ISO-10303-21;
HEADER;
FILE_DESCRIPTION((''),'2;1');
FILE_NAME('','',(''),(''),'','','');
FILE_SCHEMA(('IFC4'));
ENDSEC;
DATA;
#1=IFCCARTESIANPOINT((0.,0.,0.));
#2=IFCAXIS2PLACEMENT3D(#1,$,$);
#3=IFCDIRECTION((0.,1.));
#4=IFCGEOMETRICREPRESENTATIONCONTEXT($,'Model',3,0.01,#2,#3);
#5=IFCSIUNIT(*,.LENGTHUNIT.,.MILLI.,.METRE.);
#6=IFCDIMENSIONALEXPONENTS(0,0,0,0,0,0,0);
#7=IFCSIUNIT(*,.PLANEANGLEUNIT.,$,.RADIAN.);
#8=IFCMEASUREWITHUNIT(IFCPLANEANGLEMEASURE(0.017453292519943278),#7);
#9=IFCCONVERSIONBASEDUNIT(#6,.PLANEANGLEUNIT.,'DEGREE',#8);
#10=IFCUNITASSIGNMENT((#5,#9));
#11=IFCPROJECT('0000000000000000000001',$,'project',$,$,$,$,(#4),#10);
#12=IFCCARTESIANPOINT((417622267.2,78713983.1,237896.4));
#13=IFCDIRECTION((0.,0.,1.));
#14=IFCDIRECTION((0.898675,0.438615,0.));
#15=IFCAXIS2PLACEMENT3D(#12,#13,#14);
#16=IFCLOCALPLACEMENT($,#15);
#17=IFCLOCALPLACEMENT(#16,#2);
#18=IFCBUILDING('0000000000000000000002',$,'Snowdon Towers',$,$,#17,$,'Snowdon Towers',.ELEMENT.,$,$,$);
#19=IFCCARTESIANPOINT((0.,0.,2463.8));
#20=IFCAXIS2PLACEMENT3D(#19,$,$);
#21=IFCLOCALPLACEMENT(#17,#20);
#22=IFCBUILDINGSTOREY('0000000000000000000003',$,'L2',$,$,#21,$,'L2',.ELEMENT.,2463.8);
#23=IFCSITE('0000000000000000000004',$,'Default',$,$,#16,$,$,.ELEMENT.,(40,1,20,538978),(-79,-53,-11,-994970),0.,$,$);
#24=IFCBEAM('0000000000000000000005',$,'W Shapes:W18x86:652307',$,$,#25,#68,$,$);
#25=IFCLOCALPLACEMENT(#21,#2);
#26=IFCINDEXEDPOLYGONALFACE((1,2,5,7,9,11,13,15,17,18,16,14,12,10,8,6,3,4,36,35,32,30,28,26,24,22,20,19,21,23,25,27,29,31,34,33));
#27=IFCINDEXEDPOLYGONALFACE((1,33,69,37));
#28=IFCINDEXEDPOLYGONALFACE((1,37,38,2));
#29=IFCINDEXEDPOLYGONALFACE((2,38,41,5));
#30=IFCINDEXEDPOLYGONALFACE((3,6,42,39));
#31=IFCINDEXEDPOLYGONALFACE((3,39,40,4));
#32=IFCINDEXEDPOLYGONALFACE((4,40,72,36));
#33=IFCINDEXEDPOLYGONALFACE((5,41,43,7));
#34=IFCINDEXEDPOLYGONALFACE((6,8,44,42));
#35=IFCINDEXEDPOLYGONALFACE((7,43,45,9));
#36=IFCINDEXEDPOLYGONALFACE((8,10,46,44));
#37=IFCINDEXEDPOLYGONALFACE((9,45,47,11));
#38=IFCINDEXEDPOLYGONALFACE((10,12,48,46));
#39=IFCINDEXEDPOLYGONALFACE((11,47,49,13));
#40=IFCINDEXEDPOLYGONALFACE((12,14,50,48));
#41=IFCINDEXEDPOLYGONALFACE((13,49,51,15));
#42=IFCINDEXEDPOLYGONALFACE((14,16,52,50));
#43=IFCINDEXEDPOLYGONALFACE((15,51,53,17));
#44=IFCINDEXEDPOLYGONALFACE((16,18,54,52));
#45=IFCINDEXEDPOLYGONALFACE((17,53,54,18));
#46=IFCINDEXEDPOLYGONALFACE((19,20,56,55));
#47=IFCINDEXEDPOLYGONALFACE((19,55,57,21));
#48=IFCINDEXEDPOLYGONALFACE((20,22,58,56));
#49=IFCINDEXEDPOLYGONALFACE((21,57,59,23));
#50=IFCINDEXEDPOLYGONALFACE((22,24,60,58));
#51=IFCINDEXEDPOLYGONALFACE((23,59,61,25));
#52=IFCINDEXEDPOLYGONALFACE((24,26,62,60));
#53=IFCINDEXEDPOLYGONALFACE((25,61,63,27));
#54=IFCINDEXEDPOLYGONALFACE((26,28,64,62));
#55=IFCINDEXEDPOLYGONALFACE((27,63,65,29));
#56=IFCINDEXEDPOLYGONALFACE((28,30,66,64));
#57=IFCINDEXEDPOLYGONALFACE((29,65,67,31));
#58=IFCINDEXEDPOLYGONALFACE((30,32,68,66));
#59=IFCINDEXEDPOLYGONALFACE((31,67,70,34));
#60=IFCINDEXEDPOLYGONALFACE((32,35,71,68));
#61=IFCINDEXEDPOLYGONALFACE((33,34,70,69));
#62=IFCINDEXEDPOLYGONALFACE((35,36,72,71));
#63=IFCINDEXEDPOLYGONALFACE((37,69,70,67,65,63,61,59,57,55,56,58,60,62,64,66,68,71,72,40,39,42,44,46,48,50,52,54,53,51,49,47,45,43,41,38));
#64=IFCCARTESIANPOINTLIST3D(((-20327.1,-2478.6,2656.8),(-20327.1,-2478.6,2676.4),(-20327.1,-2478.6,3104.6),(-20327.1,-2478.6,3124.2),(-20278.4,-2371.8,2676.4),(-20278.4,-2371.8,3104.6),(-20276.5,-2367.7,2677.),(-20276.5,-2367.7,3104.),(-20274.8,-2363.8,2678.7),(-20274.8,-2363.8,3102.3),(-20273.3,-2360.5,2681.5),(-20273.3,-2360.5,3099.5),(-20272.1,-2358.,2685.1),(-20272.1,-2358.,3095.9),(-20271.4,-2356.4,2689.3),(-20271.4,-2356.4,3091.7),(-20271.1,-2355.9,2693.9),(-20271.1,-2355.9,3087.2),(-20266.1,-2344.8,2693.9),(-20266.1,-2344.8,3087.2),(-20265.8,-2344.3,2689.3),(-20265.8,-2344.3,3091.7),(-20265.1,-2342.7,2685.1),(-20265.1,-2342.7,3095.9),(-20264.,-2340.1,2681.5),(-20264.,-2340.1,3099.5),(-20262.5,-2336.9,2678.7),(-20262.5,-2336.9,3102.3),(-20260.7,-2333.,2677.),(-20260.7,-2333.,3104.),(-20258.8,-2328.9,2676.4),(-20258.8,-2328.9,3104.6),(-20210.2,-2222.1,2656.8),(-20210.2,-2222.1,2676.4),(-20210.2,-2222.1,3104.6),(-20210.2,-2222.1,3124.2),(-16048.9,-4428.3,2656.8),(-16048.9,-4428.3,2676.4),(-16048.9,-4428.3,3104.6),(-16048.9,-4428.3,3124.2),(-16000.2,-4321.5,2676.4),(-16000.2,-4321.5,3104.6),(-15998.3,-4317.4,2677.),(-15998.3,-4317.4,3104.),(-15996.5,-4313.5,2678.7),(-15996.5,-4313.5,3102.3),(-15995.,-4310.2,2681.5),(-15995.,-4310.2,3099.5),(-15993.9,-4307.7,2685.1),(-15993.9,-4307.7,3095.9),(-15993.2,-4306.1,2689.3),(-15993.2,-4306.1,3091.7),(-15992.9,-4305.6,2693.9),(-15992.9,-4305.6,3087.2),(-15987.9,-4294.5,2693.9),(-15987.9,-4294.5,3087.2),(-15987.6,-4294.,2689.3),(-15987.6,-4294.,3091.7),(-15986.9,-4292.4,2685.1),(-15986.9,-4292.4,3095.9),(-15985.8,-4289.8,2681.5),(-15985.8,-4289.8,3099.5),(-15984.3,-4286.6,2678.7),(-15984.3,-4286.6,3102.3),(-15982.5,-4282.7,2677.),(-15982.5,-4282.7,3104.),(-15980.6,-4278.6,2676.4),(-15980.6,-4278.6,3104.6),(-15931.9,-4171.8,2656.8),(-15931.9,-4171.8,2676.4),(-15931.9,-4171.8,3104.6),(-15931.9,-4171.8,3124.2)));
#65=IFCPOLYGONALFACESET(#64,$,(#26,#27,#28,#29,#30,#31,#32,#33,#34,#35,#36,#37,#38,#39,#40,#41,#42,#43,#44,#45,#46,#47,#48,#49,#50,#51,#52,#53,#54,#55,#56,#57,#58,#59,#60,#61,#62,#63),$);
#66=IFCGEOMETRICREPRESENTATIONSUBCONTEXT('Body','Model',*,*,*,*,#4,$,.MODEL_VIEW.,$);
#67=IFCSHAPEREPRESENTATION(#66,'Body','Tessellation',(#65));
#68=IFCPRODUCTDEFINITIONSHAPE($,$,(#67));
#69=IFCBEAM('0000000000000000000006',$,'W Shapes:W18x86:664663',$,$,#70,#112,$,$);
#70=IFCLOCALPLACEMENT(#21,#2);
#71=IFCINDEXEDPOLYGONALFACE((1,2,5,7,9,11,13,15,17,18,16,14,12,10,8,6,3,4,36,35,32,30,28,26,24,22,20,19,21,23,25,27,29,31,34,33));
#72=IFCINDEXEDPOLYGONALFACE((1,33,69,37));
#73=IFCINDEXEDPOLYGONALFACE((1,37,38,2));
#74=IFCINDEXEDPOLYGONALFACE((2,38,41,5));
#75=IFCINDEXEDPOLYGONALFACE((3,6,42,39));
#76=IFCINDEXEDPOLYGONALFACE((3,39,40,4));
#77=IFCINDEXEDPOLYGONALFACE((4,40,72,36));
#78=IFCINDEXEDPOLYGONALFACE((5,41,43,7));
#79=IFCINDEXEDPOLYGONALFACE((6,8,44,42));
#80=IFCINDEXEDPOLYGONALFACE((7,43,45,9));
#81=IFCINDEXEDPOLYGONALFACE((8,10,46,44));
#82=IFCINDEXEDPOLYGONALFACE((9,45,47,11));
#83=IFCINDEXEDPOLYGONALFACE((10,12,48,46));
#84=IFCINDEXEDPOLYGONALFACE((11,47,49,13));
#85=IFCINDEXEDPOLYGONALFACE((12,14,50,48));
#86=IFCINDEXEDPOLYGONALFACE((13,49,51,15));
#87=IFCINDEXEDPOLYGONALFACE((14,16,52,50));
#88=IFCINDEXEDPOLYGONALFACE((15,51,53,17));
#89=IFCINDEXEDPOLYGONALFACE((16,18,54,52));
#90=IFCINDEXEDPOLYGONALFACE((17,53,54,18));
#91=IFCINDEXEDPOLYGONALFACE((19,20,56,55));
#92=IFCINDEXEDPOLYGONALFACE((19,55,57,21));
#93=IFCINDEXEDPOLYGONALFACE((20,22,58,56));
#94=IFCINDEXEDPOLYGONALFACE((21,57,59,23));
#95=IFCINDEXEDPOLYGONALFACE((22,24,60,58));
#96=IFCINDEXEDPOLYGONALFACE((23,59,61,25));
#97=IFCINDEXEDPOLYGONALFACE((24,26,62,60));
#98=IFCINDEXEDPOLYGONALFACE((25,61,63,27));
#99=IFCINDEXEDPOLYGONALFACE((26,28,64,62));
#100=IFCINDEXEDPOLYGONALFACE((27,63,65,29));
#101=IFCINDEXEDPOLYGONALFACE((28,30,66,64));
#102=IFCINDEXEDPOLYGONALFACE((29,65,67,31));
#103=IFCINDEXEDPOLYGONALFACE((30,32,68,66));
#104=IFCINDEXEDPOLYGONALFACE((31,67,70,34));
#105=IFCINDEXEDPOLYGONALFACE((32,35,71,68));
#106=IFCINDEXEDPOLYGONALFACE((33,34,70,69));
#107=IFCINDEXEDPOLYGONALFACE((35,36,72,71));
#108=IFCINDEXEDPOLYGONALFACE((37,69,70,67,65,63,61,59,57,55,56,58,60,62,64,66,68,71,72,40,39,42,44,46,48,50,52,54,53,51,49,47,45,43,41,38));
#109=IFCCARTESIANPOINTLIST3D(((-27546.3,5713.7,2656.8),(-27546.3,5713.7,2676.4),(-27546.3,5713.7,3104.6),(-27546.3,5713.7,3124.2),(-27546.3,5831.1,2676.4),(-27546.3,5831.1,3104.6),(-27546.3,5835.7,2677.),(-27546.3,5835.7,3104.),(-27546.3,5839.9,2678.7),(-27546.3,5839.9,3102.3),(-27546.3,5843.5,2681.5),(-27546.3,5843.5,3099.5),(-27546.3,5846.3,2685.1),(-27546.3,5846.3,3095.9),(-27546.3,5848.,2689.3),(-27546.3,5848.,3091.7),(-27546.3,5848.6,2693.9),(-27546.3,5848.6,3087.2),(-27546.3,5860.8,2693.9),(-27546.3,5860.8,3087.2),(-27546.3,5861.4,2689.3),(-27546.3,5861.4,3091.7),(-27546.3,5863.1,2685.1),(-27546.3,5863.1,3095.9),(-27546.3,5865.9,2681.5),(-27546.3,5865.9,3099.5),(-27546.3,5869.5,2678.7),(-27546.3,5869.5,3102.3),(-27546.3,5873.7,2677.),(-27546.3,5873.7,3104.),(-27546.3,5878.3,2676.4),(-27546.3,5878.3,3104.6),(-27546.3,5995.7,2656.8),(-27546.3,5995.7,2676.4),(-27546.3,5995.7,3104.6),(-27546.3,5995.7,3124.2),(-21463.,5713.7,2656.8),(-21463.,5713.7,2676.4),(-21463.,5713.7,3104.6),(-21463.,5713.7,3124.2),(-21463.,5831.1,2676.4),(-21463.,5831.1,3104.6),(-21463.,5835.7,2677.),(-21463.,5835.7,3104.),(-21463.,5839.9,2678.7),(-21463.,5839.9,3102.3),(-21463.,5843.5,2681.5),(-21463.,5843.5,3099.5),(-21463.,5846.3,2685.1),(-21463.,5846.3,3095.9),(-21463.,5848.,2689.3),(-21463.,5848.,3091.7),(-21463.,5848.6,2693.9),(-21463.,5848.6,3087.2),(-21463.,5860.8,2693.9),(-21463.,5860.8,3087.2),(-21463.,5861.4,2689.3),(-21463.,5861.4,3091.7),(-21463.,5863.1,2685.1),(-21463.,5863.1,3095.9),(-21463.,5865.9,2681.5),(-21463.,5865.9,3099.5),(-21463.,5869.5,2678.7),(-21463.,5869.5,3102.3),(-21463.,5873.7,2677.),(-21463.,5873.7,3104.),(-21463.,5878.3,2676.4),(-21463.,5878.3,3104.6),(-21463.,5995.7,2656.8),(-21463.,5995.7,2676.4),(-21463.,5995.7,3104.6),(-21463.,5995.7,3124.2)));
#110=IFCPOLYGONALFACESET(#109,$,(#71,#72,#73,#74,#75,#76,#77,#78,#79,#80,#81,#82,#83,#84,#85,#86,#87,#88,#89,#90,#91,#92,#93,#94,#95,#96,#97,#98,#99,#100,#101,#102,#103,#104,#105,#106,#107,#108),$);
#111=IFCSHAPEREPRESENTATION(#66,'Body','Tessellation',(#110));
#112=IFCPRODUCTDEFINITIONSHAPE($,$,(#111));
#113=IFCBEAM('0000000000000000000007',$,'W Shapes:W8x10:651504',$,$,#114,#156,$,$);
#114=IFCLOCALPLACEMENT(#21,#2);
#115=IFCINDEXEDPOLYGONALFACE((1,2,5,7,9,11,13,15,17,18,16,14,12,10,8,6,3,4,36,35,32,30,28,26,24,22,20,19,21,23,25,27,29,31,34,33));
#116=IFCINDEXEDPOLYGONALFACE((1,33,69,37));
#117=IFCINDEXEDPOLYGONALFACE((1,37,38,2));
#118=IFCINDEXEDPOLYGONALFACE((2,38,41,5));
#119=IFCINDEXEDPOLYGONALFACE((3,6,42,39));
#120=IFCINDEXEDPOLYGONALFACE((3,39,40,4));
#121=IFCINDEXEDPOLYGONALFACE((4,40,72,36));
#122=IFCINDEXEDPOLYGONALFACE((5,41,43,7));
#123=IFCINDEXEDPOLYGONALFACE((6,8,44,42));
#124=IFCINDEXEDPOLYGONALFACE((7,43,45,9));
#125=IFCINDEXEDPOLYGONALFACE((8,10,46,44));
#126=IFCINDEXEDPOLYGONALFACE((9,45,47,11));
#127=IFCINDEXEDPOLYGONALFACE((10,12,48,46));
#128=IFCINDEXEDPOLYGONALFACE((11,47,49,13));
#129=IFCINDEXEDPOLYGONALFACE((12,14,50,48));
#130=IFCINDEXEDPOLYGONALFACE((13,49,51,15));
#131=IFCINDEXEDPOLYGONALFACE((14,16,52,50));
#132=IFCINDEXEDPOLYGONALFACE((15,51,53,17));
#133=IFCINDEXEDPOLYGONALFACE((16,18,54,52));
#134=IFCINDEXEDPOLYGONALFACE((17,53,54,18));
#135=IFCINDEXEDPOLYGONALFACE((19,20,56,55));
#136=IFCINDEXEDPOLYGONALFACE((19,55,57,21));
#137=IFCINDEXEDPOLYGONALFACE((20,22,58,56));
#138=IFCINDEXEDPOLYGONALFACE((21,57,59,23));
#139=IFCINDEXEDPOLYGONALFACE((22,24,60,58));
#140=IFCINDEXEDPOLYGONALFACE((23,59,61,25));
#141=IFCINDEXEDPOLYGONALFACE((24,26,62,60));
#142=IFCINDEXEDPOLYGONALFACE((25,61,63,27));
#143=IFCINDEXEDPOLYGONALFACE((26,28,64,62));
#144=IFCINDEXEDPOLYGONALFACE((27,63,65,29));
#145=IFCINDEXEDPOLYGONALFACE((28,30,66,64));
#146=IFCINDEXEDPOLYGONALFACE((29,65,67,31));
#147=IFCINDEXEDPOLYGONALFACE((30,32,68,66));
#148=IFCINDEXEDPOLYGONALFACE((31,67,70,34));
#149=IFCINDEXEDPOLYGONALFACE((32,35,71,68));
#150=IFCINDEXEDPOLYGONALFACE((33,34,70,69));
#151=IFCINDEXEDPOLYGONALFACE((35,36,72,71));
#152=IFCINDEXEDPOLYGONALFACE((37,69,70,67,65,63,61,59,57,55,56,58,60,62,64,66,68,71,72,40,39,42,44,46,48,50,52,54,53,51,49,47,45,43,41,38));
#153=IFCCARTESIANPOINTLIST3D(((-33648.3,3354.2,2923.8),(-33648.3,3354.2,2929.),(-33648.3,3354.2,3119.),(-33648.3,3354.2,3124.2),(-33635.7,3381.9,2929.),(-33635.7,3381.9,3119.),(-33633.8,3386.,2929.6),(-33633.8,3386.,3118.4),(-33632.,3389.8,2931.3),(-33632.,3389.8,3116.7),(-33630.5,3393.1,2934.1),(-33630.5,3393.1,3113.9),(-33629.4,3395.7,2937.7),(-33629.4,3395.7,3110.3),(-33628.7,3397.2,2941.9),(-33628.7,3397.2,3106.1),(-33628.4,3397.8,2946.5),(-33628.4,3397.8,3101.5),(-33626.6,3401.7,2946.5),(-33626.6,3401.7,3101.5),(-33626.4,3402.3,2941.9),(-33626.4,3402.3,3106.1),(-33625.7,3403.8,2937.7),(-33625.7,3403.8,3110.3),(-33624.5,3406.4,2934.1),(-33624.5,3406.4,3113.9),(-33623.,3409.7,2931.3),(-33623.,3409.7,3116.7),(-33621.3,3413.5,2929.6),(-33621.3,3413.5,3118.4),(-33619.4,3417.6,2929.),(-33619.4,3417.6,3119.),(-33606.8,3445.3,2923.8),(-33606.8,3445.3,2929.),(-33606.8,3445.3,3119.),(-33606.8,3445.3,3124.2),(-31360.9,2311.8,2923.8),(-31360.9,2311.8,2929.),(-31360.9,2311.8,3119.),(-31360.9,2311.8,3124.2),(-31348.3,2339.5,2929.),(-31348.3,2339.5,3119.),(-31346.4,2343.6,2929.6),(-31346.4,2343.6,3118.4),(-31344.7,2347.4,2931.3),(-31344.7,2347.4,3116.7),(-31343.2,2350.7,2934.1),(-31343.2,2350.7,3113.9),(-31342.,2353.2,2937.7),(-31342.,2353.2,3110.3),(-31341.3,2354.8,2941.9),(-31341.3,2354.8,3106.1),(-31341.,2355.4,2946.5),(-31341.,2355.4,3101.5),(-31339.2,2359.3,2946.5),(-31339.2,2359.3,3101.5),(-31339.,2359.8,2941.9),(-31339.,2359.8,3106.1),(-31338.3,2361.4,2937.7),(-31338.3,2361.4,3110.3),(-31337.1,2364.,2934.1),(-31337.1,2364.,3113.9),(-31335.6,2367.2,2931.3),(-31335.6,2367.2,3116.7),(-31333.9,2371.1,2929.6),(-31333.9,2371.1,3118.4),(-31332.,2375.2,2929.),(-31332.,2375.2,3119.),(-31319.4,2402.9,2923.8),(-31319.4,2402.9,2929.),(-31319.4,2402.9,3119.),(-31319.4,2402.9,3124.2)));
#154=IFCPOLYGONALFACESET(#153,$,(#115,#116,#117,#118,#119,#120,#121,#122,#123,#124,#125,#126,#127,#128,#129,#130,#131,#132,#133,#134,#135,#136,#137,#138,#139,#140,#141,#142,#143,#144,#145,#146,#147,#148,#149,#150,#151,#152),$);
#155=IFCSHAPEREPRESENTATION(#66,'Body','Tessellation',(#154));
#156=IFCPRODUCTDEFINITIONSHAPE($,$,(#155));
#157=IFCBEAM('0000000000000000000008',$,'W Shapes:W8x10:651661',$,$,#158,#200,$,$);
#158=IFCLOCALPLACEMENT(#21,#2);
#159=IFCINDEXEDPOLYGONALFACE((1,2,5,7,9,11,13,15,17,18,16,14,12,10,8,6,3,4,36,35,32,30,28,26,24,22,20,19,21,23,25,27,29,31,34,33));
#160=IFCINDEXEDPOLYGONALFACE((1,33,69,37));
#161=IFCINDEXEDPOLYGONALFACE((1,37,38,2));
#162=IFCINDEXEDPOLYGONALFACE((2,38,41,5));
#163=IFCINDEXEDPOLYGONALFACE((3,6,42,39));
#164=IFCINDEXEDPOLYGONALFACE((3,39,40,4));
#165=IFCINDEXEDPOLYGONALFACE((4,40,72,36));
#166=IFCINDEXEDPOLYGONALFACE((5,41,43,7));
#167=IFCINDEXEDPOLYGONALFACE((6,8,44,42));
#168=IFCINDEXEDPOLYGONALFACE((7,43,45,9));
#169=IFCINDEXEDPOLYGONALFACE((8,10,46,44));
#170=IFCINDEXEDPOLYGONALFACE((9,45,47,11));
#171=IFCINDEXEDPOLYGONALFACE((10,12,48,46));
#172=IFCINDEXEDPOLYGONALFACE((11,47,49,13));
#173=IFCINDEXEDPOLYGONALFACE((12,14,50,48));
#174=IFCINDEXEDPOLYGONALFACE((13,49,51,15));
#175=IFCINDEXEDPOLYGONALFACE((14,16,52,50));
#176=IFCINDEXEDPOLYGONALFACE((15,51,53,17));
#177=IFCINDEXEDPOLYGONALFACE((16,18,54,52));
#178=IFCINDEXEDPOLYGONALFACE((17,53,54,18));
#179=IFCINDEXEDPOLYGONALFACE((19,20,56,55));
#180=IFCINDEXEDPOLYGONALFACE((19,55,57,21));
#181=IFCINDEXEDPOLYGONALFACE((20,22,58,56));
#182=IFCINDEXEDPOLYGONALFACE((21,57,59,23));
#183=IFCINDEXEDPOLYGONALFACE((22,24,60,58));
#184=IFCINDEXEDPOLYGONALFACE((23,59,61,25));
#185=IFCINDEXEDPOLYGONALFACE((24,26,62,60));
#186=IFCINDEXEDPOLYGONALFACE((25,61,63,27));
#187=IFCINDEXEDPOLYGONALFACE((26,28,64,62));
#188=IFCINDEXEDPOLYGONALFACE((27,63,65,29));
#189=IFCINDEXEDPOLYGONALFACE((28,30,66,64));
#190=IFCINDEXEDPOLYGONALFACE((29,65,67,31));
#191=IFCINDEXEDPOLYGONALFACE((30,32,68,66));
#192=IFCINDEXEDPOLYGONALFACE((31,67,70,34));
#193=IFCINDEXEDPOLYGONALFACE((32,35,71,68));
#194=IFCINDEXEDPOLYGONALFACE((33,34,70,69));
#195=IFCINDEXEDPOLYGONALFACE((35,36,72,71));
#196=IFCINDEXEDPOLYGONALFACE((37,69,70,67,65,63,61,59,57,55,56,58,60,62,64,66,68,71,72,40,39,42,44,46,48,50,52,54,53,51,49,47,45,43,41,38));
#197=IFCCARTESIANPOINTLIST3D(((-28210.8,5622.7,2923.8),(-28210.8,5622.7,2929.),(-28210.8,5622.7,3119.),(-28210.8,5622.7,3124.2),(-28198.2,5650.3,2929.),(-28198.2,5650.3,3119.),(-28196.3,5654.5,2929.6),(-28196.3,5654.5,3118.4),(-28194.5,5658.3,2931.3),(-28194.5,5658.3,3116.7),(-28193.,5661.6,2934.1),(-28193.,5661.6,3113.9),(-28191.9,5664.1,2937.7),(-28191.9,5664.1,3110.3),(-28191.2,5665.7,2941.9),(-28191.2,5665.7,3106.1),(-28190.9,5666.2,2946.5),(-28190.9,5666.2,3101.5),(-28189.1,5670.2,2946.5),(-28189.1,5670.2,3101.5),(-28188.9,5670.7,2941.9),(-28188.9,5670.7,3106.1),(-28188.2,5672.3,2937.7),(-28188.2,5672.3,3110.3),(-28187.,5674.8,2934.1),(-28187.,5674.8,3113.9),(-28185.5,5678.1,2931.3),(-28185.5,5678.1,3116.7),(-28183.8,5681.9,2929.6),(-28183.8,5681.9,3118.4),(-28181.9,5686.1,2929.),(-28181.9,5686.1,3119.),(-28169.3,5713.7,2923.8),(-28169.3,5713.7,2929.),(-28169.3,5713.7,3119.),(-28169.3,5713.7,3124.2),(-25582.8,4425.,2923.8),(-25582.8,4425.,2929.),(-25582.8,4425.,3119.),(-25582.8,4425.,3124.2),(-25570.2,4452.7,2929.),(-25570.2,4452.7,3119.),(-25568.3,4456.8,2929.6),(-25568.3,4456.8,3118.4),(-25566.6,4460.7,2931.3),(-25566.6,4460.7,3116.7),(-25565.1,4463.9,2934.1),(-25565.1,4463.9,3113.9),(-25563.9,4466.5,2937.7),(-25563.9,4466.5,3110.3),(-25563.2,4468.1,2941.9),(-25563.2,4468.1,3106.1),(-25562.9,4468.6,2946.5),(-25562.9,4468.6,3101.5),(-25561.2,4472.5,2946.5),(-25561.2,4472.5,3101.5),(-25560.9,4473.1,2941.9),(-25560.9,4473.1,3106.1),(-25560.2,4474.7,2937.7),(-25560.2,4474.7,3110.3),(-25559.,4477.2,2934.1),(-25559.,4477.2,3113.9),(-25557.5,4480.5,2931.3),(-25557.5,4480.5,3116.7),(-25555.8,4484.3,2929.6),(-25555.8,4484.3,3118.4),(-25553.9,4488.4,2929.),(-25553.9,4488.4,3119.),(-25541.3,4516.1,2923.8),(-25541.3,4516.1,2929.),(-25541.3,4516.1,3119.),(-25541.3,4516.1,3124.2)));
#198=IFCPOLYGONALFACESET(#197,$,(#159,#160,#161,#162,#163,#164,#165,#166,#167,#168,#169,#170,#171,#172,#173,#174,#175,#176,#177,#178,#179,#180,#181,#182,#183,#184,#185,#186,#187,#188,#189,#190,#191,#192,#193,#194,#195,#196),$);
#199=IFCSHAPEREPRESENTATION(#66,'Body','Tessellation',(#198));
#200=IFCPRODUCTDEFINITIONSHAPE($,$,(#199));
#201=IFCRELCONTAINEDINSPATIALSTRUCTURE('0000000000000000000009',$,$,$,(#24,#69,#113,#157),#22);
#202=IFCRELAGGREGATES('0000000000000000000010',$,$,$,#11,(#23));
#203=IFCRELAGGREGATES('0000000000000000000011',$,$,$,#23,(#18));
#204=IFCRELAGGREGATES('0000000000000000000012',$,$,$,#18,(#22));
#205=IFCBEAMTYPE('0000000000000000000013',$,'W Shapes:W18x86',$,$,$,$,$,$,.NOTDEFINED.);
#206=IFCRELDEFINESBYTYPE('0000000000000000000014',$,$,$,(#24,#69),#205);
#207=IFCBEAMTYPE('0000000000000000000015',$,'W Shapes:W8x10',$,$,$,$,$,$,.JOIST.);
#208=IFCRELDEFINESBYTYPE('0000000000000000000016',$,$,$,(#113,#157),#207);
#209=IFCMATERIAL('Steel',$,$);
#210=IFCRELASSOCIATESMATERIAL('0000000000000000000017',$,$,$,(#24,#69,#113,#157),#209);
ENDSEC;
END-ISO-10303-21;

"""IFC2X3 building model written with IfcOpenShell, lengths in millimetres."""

from ifc_helpers import new_model, entity, si_unit, converted_unit, direction, frame, frame_2d, origin, place, context, subcontext, project, spatial, i_section, extrude, material, type_object, element, save


model = new_model("IFC2X3")

# Units and contexts
model_context = context("Model", 3, precision=0.01, world=origin(), true_north=direction((0.0, 1.0)))
body_context = subcontext(model_context, "Body", "Model", "MODEL_VIEW")
ifc_project = project(units=[si_unit("LENGTHUNIT", "METRE", prefix="MILLI"), converted_unit("PLANEANGLEUNIT", "DEGREE", entity("IfcPlaneAngleMeasure", 0.017453292519943278), si_unit("PLANEANGLEUNIT", "RADIAN"), dimensions=[0, 0, 0, 0, 0, 0, 0])], contexts=[model_context])

# Site, building, storey
site_placement = place(None, frame((417622267.2, 78713983.1, 237896.4), z_axis=(0.0, 0.0, 1.0), x_axis=(0.898675, 0.438615, 0.0)))
site = spatial("IfcSite", under=ifc_project, at=site_placement, Name="Default", CompositionType="ELEMENT", RefLatitude=(40, 1, 20, 538978), RefLongitude=(-79, -53, -11, -994970), RefElevation=0.0)
building_placement = place(site_placement, origin())
building = spatial("IfcBuilding", under=site, at=building_placement, Name="Snowdon Towers", LongName="Snowdon Towers", CompositionType="ELEMENT")
storey_placement = place(building_placement, frame((0.0, 0.0, 2463.8)))
storey = spatial("IfcBuildingStorey", under=building, at=storey_placement, Name="L2", LongName="L2", CompositionType="ELEMENT", Elevation=2463.8)

# Beams
ifc_material = material(Name="Steel")
beam_type_1 = type_object("IfcBeamType", Name="W Shapes:W18x86", PredefinedType="NOTDEFINED")
beam_1_placement = place(storey_placement, frame((-20140.3, -2408.8, 3124.2), z_axis=(0.0, 0.0, 1.0), x_axis=(0.909961, -0.414693, 0.0)))
element("IfcBeam", 1, at=beam_1_placement, inside=storey, type_object=beam_type_1, material=ifc_material, Name="W Shapes:W18x86:652307", context=body_context, shape_type="SweptSolid", body=[
    extrude(i_section(OverallWidth=281.9, OverallDepth=467.4, WebThickness=12.2, FlangeThickness=19.6, FilletRadius=17.5, at=frame_2d((0.0, 0.0), x_axis=(0.0, 1.0))), frame((-141.0, 0.0, -233.7), z_axis=(1.0, 0.0, 0.0), x_axis=(0.0, 0.0, -1.0)), (0.0, 0.0, 1.0), 4701.5),
])
beam_2_placement = place(storey_placement, frame((-27673.3, 5854.7, 3124.2)))
element("IfcBeam", 2, at=beam_2_placement, inside=storey, type_object=beam_type_1, material=ifc_material, Name="W Shapes:W18x86:664663", context=body_context, shape_type="SweptSolid", body=[
    extrude(i_section(OverallWidth=281.9, OverallDepth=467.4, WebThickness=12.2, FlangeThickness=19.6, FilletRadius=17.5, at=frame_2d((0.0, 0.0), x_axis=(0.0, 1.0))), frame((127.0, 0.0, -233.7), z_axis=(1.0, 0.0, 0.0), x_axis=(0.0, 0.0, -1.0)), (0.0, 0.0, 1.0), 6083.3),
])
beam_type_2 = type_object("IfcBeamType", Name="W Shapes:W8x10", PredefinedType="JOIST")
beam_3_placement = place(storey_placement, frame((-33743.9, 3452.8, 3124.2), z_axis=(0.0, 0.0, 1.0), x_axis=(0.909961, -0.414693, 0.0)))
element("IfcBeam", 3, at=beam_3_placement, inside=storey, type_object=beam_type_2, material=ifc_material, Name="W Shapes:W8x10:651504", context=body_context, shape_type="SweptSolid", body=[
    extrude(i_section(OverallWidth=100.1, OverallDepth=200.4, WebThickness=4.3, FlangeThickness=5.2, FilletRadius=17.5, at=frame_2d((0.0, 0.0), x_axis=(0.0, 1.0))), frame((127.9, 0.0, -100.2), z_axis=(1.0, 0.0, 0.0), x_axis=(0.0, 0.0, -1.0)), (0.0, 0.0, 1.0), 2513.7),
])
beam_4_placement = place(storey_placement, frame((-28599.3, 5854.7, 3124.2), z_axis=(0.0, 0.0, 1.0), x_axis=(0.909961, -0.414693, 0.0)))
element("IfcBeam", 4, at=beam_4_placement, inside=storey, type_object=beam_type_2, material=ifc_material, Name="W Shapes:W8x10:651661", context=body_context, shape_type="SweptSolid", body=[
    extrude(i_section(OverallWidth=100.1, OverallDepth=200.4, WebThickness=4.3, FlangeThickness=5.2, FilletRadius=17.5, at=frame_2d((0.0, 0.0), x_axis=(0.0, 1.0))), frame((449.7, 0.0, -100.2), z_axis=(1.0, 0.0, 0.0), x_axis=(0.0, 0.0, -1.0)), (0.0, 0.0, 1.0), 2888.0),
])

save(model, "model.ifc")
